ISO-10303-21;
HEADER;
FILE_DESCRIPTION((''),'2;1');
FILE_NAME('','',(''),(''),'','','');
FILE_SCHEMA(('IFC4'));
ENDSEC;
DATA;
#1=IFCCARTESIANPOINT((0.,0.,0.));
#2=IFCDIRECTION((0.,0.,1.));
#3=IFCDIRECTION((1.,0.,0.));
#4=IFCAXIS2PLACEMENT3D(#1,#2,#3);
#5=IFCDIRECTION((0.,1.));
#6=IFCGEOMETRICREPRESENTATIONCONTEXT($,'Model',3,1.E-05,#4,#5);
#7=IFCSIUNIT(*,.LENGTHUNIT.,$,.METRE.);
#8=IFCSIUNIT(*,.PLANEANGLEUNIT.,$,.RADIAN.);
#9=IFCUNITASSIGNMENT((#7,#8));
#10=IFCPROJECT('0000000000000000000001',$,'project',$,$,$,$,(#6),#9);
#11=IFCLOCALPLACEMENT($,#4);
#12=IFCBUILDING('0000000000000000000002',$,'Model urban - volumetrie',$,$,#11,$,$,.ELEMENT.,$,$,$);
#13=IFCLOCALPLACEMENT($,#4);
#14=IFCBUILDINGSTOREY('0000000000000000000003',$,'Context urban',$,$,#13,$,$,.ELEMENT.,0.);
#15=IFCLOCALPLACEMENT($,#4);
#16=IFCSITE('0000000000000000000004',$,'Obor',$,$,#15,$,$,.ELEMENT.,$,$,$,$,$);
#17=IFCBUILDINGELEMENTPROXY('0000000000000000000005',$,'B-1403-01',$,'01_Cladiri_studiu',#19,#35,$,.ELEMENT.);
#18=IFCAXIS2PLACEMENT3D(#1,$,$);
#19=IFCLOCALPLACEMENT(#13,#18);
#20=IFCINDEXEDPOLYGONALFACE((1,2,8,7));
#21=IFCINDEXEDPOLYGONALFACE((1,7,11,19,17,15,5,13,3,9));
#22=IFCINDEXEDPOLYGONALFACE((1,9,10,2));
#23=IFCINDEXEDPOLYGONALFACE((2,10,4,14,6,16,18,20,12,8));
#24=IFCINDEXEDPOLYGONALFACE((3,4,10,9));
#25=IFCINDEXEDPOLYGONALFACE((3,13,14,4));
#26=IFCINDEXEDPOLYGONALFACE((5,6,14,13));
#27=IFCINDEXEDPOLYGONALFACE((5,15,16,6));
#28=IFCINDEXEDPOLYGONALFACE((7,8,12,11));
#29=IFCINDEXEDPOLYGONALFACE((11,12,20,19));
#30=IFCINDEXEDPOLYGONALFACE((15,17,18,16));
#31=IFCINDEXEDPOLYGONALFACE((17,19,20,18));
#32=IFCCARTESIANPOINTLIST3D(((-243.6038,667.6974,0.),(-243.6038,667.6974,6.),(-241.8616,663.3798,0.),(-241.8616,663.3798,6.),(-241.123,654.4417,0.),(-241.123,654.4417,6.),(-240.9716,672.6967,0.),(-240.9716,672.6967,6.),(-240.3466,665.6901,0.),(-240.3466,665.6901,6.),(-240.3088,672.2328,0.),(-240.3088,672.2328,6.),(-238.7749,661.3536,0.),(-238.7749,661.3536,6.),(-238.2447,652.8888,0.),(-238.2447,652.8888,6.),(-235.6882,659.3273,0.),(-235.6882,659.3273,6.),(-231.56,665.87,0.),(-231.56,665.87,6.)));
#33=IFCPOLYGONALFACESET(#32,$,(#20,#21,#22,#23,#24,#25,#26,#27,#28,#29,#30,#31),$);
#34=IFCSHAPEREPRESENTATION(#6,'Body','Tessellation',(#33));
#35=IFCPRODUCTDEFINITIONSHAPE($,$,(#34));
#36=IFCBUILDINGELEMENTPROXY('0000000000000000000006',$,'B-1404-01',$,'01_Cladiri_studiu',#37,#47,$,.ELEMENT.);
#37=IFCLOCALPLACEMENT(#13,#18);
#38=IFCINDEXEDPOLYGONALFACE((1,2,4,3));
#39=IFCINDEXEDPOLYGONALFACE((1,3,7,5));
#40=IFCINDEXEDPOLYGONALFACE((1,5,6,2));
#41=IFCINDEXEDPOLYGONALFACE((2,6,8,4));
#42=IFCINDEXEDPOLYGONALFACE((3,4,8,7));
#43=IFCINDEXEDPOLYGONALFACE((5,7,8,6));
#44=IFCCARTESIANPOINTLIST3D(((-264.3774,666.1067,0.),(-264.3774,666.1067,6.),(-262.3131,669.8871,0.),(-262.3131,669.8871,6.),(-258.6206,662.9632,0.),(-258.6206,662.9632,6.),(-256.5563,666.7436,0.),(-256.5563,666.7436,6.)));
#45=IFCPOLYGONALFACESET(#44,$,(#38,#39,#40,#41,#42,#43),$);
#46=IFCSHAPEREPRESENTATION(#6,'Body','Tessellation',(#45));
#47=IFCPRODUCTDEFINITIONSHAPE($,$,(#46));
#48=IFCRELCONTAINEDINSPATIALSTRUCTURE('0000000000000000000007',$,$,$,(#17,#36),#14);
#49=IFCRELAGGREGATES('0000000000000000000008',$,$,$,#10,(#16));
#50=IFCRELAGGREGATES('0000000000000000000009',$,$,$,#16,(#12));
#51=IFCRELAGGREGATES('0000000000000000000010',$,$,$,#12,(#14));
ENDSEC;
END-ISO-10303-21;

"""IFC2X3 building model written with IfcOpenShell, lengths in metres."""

from ifc_helpers import new_model, si_unit, direction, origin_with_axes, place, context, project, spatial, polyline, outline, extrude, element, save


model = new_model("IFC2X3")

# Units and contexts
model_context = context("Model", 3, precision=1e-05, world=origin_with_axes(), true_north=direction((0.0, 1.0)))
ifc_project = project(units=[si_unit("LENGTHUNIT", "METRE"), si_unit("PLANEANGLEUNIT", "RADIAN")], contexts=[model_context])

# Site, building, storey
site_placement = place(None, origin_with_axes())
site = spatial("IfcSite", under=ifc_project, at=site_placement, Name="Obor", CompositionType="ELEMENT")
building_placement = place(None, origin_with_axes())
building = spatial("IfcBuilding", under=site, at=building_placement, Name="Model urban - volumetrie", CompositionType="ELEMENT")
storey_placement = place(None, origin_with_axes())
storey = spatial("IfcBuildingStorey", under=building, at=storey_placement, Name="Context urban", CompositionType="ELEMENT", Elevation=0.0)

# Building element proxies
proxy_1_placement = place(None, origin_with_axes())
element("IfcBuildingElementProxy", 1, at=proxy_1_placement, inside=storey, Name="B-1403-01", ObjectType="01_Cladiri_studiu", CompositionType="ELEMENT", context=model_context, shape_type="SweptSolid", body=[
    extrude(outline(polyline([(-238.2447, 652.8888), (-235.6882, 659.3273), (-231.56, 665.87), (-240.3088, 672.2328), (-240.9716, 672.6967), (-243.6038, 667.6974), (-240.3466, 665.6901), (-241.8616, 663.3798), (-238.7749, 661.3536), (-241.123, 654.4417), (-238.2447, 652.8888)])), origin_with_axes(), (0.0, 0.0, 1.0), 6.0),
])
proxy_2_placement = place(None, origin_with_axes())
element("IfcBuildingElementProxy", 2, at=proxy_2_placement, inside=storey, Name="B-1404-01", ObjectType="01_Cladiri_studiu", CompositionType="ELEMENT", context=model_context, shape_type="SweptSolid", body=[
    extrude(outline(polyline([(-256.5563, 666.7436), (-262.3131, 669.8871), (-264.3774, 666.1067), (-258.6206, 662.9632), (-256.5563, 666.7436)])), origin_with_axes(), (0.0, 0.0, 1.0), 6.0),
])

save(model, "model.ifc")
